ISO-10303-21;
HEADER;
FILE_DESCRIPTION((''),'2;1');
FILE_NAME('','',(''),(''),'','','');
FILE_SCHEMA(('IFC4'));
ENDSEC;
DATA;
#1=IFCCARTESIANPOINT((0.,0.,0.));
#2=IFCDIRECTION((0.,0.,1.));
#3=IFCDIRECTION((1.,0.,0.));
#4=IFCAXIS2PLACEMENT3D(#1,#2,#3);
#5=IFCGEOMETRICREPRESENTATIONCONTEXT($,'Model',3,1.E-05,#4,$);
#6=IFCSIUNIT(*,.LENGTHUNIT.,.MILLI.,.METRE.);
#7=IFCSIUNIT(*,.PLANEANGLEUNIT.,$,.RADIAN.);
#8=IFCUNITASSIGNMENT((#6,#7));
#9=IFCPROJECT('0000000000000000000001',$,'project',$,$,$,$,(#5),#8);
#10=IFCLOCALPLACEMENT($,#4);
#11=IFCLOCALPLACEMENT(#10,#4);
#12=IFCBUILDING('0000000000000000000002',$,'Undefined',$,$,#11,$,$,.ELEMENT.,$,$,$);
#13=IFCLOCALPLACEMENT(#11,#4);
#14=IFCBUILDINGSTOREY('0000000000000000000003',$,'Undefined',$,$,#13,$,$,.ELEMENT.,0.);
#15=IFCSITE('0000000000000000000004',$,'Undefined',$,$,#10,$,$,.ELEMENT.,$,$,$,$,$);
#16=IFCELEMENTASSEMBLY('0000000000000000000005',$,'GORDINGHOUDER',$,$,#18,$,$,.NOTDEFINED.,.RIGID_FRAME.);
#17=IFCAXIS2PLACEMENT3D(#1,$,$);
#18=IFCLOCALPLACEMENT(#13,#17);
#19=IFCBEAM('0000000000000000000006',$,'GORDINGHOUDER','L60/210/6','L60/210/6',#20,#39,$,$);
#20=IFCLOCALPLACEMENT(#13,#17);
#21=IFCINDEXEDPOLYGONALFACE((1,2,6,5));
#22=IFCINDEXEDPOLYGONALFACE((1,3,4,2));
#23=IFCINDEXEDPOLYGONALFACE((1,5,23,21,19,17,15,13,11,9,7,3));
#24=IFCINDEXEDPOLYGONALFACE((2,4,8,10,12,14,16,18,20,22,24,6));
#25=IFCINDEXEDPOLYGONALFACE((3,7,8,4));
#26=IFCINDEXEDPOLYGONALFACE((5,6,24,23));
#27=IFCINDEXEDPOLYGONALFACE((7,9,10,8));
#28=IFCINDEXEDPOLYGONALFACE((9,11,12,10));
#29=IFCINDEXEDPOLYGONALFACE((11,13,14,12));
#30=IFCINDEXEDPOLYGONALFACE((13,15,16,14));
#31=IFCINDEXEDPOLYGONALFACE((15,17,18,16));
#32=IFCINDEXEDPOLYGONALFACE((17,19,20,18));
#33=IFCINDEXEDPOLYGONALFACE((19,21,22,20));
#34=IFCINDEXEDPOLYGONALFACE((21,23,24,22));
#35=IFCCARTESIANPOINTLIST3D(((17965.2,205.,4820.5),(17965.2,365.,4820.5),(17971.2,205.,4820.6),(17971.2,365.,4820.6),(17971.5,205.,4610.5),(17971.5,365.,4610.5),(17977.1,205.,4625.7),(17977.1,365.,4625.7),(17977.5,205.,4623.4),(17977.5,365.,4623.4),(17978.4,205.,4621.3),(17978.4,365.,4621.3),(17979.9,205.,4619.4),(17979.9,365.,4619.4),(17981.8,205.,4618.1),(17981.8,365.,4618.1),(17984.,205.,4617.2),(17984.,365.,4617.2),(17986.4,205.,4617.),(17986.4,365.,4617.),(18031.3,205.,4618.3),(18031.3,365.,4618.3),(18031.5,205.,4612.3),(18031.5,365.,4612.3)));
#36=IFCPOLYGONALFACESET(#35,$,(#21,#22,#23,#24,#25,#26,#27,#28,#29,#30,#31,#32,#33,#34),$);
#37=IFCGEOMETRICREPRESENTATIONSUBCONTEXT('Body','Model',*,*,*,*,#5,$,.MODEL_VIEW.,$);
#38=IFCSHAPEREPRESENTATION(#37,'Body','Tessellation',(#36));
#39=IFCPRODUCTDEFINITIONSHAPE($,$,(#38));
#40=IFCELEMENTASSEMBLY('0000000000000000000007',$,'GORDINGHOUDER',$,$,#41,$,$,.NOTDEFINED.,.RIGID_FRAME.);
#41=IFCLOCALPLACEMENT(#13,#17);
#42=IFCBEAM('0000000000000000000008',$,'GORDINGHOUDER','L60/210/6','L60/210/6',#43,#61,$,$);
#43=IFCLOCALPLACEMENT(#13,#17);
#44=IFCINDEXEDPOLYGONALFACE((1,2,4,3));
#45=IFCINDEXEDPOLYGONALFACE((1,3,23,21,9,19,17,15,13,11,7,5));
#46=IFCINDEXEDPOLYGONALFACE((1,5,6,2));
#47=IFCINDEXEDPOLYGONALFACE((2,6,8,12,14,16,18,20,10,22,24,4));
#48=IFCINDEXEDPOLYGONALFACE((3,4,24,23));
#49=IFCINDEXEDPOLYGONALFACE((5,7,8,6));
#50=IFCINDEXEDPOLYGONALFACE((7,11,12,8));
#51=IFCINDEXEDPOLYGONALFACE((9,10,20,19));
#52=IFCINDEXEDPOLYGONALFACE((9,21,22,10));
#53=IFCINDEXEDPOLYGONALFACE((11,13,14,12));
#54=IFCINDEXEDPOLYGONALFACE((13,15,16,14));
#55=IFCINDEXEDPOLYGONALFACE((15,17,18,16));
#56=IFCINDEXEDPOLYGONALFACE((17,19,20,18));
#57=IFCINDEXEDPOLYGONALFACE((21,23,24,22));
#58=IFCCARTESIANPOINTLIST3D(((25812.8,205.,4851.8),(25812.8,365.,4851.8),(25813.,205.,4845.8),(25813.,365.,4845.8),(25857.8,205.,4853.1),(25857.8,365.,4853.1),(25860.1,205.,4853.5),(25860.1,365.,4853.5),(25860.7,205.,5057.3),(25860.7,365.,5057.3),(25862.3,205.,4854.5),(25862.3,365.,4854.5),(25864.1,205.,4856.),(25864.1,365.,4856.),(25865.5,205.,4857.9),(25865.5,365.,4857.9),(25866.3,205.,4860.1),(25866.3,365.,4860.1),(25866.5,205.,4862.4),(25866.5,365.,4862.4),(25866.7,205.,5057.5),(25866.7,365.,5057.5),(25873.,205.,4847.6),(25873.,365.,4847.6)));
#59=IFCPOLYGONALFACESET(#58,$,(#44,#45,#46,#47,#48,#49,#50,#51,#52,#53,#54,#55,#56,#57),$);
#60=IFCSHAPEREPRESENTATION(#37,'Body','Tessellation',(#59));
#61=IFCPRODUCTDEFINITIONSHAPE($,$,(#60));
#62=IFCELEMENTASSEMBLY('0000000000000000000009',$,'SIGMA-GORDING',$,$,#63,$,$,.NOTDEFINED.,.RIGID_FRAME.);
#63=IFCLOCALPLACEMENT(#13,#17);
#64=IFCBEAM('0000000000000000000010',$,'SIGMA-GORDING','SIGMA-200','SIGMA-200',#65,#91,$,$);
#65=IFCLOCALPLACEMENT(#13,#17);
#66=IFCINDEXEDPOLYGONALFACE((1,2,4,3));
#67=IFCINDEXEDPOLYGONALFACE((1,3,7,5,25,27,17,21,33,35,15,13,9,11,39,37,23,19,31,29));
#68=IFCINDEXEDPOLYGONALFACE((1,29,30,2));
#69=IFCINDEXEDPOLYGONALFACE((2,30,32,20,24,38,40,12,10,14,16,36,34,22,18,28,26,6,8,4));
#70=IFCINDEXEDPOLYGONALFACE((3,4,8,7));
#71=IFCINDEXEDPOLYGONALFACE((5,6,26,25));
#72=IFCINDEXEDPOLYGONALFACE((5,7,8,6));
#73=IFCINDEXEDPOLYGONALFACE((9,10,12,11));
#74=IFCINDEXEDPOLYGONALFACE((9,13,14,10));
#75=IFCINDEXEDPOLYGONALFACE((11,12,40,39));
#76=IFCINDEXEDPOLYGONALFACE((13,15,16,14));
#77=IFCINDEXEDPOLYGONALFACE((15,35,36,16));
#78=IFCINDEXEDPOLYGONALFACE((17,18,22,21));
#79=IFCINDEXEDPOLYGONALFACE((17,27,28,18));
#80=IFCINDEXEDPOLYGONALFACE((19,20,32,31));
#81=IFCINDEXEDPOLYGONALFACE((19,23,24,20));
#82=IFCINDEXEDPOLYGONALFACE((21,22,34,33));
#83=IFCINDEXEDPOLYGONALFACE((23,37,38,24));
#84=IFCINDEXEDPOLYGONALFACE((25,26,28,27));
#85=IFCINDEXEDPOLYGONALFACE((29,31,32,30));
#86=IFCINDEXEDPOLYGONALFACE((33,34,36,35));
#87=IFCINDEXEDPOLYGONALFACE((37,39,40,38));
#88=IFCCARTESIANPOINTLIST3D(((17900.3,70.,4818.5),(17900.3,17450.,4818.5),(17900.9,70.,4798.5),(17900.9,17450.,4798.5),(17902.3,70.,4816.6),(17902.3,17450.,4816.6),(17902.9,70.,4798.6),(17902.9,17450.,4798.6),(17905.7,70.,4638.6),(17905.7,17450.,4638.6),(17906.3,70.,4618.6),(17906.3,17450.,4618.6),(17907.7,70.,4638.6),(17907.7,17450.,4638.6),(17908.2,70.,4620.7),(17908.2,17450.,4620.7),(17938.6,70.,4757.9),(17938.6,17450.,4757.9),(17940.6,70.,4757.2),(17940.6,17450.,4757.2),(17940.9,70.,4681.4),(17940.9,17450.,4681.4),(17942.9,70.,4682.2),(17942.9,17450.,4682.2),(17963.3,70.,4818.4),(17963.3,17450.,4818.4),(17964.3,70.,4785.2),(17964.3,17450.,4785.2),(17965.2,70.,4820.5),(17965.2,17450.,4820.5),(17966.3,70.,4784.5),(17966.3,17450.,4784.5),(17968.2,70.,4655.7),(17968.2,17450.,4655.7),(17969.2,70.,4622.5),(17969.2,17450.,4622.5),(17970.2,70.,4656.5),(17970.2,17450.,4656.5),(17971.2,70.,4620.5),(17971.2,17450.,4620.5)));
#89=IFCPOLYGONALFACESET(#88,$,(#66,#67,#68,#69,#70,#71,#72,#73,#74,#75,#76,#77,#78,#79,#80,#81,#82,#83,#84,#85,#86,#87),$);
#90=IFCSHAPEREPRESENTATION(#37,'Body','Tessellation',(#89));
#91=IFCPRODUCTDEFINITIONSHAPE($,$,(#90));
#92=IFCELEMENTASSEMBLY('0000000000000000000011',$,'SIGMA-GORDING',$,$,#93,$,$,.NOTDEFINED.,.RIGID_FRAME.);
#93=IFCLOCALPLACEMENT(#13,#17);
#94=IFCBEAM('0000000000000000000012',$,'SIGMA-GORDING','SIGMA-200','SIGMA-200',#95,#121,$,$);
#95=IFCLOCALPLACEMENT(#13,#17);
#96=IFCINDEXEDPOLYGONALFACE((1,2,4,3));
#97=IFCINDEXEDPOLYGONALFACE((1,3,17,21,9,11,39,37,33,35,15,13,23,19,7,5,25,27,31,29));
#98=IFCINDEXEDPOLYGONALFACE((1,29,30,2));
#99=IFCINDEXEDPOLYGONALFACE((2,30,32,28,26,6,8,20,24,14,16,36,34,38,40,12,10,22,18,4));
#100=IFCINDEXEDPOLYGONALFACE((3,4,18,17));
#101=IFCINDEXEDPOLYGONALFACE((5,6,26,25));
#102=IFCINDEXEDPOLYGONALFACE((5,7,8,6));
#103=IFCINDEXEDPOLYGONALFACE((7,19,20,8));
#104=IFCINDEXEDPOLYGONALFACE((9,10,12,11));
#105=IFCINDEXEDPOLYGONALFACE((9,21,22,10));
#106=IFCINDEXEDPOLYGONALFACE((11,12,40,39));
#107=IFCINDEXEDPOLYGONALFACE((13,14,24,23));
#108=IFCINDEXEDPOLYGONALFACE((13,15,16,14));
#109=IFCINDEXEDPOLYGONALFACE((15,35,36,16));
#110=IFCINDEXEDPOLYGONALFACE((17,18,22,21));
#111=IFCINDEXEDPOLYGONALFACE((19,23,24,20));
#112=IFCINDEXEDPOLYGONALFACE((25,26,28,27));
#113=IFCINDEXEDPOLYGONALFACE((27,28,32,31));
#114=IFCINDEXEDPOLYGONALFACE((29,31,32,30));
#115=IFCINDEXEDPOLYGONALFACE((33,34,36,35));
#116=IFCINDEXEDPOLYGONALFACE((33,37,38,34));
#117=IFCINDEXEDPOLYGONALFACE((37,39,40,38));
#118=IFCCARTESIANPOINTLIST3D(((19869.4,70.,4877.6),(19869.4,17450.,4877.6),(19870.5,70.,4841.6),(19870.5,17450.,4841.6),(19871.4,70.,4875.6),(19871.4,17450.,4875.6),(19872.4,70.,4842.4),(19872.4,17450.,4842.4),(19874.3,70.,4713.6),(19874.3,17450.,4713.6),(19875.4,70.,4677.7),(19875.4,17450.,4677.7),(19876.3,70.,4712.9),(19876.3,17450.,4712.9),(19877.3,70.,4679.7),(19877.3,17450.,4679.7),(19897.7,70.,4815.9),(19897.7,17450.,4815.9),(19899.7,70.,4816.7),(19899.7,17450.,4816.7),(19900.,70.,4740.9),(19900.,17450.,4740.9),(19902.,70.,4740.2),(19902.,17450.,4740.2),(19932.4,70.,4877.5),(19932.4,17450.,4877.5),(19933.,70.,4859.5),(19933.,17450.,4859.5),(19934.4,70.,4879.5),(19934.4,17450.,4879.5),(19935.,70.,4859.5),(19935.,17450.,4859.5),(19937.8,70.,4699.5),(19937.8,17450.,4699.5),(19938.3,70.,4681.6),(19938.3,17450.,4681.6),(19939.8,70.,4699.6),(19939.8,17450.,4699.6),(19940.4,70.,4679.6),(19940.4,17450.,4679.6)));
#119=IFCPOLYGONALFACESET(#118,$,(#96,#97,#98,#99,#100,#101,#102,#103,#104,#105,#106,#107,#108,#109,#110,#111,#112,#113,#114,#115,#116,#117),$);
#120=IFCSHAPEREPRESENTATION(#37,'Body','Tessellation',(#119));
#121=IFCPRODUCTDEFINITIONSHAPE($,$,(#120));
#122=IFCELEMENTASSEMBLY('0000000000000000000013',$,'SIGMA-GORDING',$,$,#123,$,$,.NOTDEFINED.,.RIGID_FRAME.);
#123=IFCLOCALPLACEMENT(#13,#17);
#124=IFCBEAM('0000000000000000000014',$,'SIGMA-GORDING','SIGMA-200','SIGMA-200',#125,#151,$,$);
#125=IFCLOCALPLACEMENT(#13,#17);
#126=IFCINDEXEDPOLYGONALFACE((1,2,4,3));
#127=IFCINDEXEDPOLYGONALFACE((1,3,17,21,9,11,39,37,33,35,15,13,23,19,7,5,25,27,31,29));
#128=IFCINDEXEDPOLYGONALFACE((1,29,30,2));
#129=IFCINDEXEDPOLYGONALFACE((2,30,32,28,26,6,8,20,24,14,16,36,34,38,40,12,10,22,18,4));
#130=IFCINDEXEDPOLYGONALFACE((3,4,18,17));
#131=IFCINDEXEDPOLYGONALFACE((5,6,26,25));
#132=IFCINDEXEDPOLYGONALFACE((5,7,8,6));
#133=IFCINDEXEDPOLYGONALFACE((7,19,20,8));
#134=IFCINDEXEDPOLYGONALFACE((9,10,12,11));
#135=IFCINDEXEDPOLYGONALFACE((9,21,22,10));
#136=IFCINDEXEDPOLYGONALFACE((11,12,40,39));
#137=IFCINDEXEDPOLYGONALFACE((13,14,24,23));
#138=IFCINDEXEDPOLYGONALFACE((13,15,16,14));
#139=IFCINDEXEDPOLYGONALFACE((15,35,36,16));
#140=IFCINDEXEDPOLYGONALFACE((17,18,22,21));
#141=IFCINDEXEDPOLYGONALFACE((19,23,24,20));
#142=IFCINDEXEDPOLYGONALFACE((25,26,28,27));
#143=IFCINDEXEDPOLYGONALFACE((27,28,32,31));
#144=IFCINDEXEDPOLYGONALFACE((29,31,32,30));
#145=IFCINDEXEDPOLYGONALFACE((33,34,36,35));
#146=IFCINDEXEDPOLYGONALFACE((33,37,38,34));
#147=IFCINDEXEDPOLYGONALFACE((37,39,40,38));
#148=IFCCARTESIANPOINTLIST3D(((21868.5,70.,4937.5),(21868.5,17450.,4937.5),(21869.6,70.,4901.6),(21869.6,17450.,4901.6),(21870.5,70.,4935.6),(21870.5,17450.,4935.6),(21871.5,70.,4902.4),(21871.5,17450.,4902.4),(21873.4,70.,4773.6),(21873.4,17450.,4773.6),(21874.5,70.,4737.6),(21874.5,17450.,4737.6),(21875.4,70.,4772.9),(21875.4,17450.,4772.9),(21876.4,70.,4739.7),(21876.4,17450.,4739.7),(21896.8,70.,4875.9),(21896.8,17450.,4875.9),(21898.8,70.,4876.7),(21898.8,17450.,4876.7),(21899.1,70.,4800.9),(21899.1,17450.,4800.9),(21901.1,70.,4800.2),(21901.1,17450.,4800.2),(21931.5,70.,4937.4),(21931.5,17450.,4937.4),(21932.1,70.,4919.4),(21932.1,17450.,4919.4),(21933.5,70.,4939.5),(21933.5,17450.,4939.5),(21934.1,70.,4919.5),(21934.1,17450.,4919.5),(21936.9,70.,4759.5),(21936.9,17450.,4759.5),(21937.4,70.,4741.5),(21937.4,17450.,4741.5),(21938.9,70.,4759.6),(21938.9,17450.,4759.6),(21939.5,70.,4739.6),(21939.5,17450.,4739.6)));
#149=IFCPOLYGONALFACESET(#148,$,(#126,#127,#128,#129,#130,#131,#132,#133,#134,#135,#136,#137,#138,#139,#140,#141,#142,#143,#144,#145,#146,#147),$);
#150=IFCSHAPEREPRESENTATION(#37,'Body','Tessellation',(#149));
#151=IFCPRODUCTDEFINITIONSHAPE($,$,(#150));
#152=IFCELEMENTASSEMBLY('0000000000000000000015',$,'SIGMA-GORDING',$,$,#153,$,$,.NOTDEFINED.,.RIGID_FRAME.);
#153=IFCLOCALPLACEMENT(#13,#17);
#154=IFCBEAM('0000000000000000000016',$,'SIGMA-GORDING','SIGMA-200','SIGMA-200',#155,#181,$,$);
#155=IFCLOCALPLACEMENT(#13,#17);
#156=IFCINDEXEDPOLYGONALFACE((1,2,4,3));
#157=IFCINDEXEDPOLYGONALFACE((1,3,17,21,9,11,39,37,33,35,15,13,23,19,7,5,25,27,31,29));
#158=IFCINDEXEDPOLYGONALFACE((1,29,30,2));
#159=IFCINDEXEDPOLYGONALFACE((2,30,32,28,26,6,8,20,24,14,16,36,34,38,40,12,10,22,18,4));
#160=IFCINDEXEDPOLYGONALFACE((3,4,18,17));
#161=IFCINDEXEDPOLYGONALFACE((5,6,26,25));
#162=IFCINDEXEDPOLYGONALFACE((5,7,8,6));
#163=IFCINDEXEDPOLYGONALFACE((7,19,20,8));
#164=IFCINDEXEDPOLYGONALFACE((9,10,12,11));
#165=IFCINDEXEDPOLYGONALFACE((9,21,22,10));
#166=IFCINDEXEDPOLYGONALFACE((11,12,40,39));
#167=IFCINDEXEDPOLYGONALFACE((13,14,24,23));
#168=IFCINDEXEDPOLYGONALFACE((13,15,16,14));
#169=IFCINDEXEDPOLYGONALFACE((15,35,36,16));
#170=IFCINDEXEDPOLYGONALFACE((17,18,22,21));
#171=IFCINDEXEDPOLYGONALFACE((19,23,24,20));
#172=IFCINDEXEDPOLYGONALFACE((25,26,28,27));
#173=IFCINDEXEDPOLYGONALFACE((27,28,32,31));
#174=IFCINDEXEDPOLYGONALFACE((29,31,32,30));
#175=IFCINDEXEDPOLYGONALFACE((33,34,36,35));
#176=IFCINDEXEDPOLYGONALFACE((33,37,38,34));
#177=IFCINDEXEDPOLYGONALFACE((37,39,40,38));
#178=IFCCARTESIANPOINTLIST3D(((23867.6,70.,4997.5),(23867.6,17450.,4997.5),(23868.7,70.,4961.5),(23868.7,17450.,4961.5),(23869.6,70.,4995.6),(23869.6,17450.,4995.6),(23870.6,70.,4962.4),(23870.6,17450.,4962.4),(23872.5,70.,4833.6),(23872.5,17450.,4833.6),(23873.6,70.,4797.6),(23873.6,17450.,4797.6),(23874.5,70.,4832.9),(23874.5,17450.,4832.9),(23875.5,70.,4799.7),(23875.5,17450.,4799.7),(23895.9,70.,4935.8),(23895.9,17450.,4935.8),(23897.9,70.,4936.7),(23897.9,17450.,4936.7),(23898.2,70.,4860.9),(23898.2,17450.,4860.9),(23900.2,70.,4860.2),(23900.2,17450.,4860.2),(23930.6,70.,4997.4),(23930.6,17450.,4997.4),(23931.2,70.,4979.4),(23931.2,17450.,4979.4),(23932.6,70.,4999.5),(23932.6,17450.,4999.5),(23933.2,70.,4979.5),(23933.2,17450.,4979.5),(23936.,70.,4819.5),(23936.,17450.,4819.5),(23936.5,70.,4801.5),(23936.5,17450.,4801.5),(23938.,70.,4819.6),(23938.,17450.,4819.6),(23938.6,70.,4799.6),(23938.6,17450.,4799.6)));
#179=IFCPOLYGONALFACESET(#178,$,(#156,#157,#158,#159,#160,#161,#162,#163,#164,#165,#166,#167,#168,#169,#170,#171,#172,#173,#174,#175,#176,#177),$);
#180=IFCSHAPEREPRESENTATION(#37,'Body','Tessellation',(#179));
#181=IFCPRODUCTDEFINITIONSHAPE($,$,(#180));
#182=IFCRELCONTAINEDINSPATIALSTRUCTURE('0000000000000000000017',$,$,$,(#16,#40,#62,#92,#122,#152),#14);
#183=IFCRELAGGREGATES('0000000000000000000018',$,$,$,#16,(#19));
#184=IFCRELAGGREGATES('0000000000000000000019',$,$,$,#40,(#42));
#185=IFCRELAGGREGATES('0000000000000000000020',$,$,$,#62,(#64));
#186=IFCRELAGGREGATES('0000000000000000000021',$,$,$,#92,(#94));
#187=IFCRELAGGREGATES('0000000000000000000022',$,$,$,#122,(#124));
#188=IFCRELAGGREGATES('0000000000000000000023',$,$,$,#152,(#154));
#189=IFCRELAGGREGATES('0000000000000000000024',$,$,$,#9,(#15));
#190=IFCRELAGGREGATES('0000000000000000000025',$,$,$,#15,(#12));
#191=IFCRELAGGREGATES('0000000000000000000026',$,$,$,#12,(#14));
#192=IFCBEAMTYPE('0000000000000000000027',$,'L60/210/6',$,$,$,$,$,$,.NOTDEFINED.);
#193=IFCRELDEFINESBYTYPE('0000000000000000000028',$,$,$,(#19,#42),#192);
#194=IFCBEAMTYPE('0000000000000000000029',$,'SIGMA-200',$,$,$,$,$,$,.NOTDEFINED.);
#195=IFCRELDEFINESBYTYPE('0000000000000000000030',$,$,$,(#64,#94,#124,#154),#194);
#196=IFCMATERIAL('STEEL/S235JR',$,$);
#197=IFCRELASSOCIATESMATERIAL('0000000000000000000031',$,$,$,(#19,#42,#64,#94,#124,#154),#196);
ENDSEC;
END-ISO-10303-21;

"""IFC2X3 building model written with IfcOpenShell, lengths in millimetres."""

from ifc_helpers import new_model, si_unit, frame, frame_2d, origin_with_axes, place, context, subcontext, project, spatial, polyline, l_section, outline, extrude, material, type_object, element, aggregate, save


model = new_model("IFC2X3")

# Units and contexts
model_context = context("Model", 3, precision=1e-05, world=origin_with_axes())
body_context = subcontext(model_context, "Body", "Model", "MODEL_VIEW")
ifc_project = project(units=[si_unit("LENGTHUNIT", "METRE", prefix="MILLI"), si_unit("PLANEANGLEUNIT", "RADIAN")], contexts=[model_context])

# Site, building, storey
site_placement = place(None, origin_with_axes())
site = spatial("IfcSite", under=ifc_project, at=site_placement, Name="Undefined", CompositionType="ELEMENT")
building_placement = place(site_placement, origin_with_axes())
building = spatial("IfcBuilding", under=site, at=building_placement, Name="Undefined", CompositionType="ELEMENT")
storey_placement = place(building_placement, origin_with_axes())
storey = spatial("IfcBuildingStorey", under=building, at=storey_placement, Name="Undefined", CompositionType="ELEMENT", Elevation=0.0)

# Element assemblies, beams
ifc_material_1 = material(Name="STEEL/S235JR")
beam_type_1 = type_object("IfcBeamType", Name="L60/210/6", PredefinedType="NOTDEFINED")
assembly_1_placement = place(storey_placement, origin_with_axes())
assembly_1 = element("IfcElementAssembly", 1, at=assembly_1_placement, inside=storey, Name="GORDINGHOUDER", AssemblyPlace="NOTDEFINED", PredefinedType="RIGID_FRAME")
beam_1_placement = place(assembly_1_placement, frame((17998.4, 365.0, 4716.4), z_axis=(0.99955, 0.0, 0.029986), x_axis=(0.0, -1.0, 0.0)))
beam_1 = element("IfcBeam", 2, at=beam_1_placement, type_object=beam_type_1, material=ifc_material_1, Name="GORDINGHOUDER", Description="L60/210/6", ObjectType="L60/210/6", context=body_context, shape_type="SweptSolid", body=[
    extrude(l_section(Depth=60.0, Width=210.0, Thickness=6.0, FilletRadius=9.0, at=frame_2d((0.0, 0.0), x_axis=(1.0, 0.0))), frame((160.0, 0.0, 0.0), z_axis=(-1.0, 0.0, 0.0), x_axis=(0.0, -1.0, 0.0)), (0.0, 0.0, 1.0), 160.0),
])
aggregate(assembly_1, [beam_1])
assembly_2_placement = place(storey_placement, origin_with_axes())
assembly_2 = element("IfcElementAssembly", 3, at=assembly_2_placement, inside=storey, Name="GORDINGHOUDER", AssemblyPlace="NOTDEFINED", PredefinedType="RIGID_FRAME")
beam_2_placement = place(assembly_2_placement, frame((25839.8, 205.0, 4951.6), z_axis=(-0.99955, 0.0, -0.029987), x_axis=(0.0, 1.0, 0.0)))
beam_2 = element("IfcBeam", 4, at=beam_2_placement, type_object=beam_type_1, material=ifc_material_1, Name="GORDINGHOUDER", Description="L60/210/6", ObjectType="L60/210/6", context=body_context, shape_type="SweptSolid", body=[
    extrude(l_section(Depth=60.0, Width=210.0, Thickness=6.0, FilletRadius=9.0, at=frame_2d((0.0, 0.0), x_axis=(1.0, 0.0))), frame((160.0, 0.0, 0.0), z_axis=(-1.0, 0.0, 0.0), x_axis=(0.0, -1.0, 0.0)), (0.0, 0.0, 1.0), 160.0),
])
aggregate(assembly_2, [beam_2])
assembly_3_placement = place(storey_placement, origin_with_axes())
assembly_3 = element("IfcElementAssembly", 5, at=assembly_3_placement, inside=storey, Name="SIGMA-GORDING", AssemblyPlace="NOTDEFINED", PredefinedType="RIGID_FRAME")
beam_type_2 = type_object("IfcBeamType", Name="SIGMA-200", PredefinedType="NOTDEFINED")
beam_3_placement = place(assembly_3_placement, frame((17935.8, 70.0, 4719.5), z_axis=(0.029987, 0.0, -0.99955), x_axis=(0.0, 1.0, 0.0)))
beam_3 = element("IfcBeam", 6, at=beam_3_placement, type_object=beam_type_2, material=ifc_material_1, Name="SIGMA-GORDING", Description="SIGMA-200", ObjectType="SIGMA-200", context=body_context, shape_type="SweptSolid", body=[
    extrude(outline(polyline([(-6.0, 37.5), (-32.5, 64.0), (-32.5, 100.0), (32.5, 100.0), (32.5, 80.0), (30.5, 80.0), (30.5, 98.0), (-30.5, 98.0), (-30.5, 64.8), (-4.0, 38.3), (-4.0, -38.3), (-30.5, -64.8), (-30.5, -98.0), (30.5, -98.0), (30.5, -80.0), (32.5, -80.0), (32.5, -100.0), (-32.5, -100.0), (-32.5, -64.0), (-6.0, -37.5), (-6.0, 37.5)])), frame((17380.0, 0.0, 0.0), z_axis=(-1.0, 0.0, 0.0), x_axis=(0.0, -1.0, 0.0)), (0.0, 0.0, 1.0), 17380.0),
])
aggregate(assembly_3, [beam_3])
assembly_4_placement = place(storey_placement, origin_with_axes())
assembly_4 = element("IfcElementAssembly", 7, at=assembly_4_placement, inside=storey, Name="SIGMA-GORDING", AssemblyPlace="NOTDEFINED", PredefinedType="RIGID_FRAME")
beam_4_placement = place(assembly_4_placement, frame((19904.9, 70.0, 4778.6), z_axis=(-0.029987, 0.0, 0.99955), x_axis=(0.0, 1.0, 0.0)))
beam_4 = element("IfcBeam", 8, at=beam_4_placement, type_object=beam_type_2, material=ifc_material_1, Name="SIGMA-GORDING", Description="SIGMA-200", ObjectType="SIGMA-200", context=body_context, shape_type="SweptSolid", body=[
    extrude(outline(polyline([(-6.0, 37.5), (-32.5, 64.0), (-32.5, 100.0), (32.5, 100.0), (32.5, 80.0), (30.5, 80.0), (30.5, 98.0), (-30.5, 98.0), (-30.5, 64.8), (-4.0, 38.3), (-4.0, -38.3), (-30.5, -64.8), (-30.5, -98.0), (30.5, -98.0), (30.5, -80.0), (32.5, -80.0), (32.5, -100.0), (-32.5, -100.0), (-32.5, -64.0), (-6.0, -37.5), (-6.0, 37.5)])), frame((17380.0, 0.0, 0.0), z_axis=(-1.0, 0.0, 0.0), x_axis=(0.0, -1.0, 0.0)), (0.0, 0.0, 1.0), 17380.0),
])
aggregate(assembly_4, [beam_4])
assembly_5_placement = place(storey_placement, origin_with_axes())
assembly_5 = element("IfcElementAssembly", 9, at=assembly_5_placement, inside=storey, Name="SIGMA-GORDING", AssemblyPlace="NOTDEFINED", PredefinedType="RIGID_FRAME")
beam_5_placement = place(assembly_5_placement, frame((21904.0, 70.0, 4838.6), z_axis=(-0.029987, 0.0, 0.99955), x_axis=(0.0, 1.0, 0.0)))
beam_5 = element("IfcBeam", 10, at=beam_5_placement, type_object=beam_type_2, material=ifc_material_1, Name="SIGMA-GORDING", Description="SIGMA-200", ObjectType="SIGMA-200", context=body_context, shape_type="SweptSolid", body=[
    extrude(outline(polyline([(-6.0, 37.5), (-32.5, 64.0), (-32.5, 100.0), (32.5, 100.0), (32.5, 80.0), (30.5, 80.0), (30.5, 98.0), (-30.5, 98.0), (-30.5, 64.8), (-4.0, 38.3), (-4.0, -38.3), (-30.5, -64.8), (-30.5, -98.0), (30.5, -98.0), (30.5, -80.0), (32.5, -80.0), (32.5, -100.0), (-32.5, -100.0), (-32.5, -64.0), (-6.0, -37.5), (-6.0, 37.5)])), frame((17380.0, 0.0, 0.0), z_axis=(-1.0, 0.0, 0.0), x_axis=(0.0, -1.0, 0.0)), (0.0, 0.0, 1.0), 17380.0),
])
aggregate(assembly_5, [beam_5])
assembly_6_placement = place(storey_placement, origin_with_axes())
assembly_6 = element("IfcElementAssembly", 11, at=assembly_6_placement, inside=storey, Name="SIGMA-GORDING", AssemblyPlace="NOTDEFINED", PredefinedType="RIGID_FRAME")
beam_6_placement = place(assembly_6_placement, frame((23903.1, 70.0, 4898.5), z_axis=(-0.029987, 0.0, 0.99955), x_axis=(0.0, 1.0, 0.0)))
beam_6 = element("IfcBeam", 12, at=beam_6_placement, type_object=beam_type_2, material=ifc_material_1, Name="SIGMA-GORDING", Description="SIGMA-200", ObjectType="SIGMA-200", context=body_context, shape_type="SweptSolid", body=[
    extrude(outline(polyline([(-6.0, 37.5), (-32.5, 64.0), (-32.5, 100.0), (32.5, 100.0), (32.5, 80.0), (30.5, 80.0), (30.5, 98.0), (-30.5, 98.0), (-30.5, 64.8), (-4.0, 38.3), (-4.0, -38.3), (-30.5, -64.8), (-30.5, -98.0), (30.5, -98.0), (30.5, -80.0), (32.5, -80.0), (32.5, -100.0), (-32.5, -100.0), (-32.5, -64.0), (-6.0, -37.5), (-6.0, 37.5)])), frame((17380.0, 0.0, 0.0), z_axis=(-1.0, 0.0, 0.0), x_axis=(0.0, -1.0, 0.0)), (0.0, 0.0, 1.0), 17380.0),
])
aggregate(assembly_6, [beam_6])

save(model, "model.ifc")
